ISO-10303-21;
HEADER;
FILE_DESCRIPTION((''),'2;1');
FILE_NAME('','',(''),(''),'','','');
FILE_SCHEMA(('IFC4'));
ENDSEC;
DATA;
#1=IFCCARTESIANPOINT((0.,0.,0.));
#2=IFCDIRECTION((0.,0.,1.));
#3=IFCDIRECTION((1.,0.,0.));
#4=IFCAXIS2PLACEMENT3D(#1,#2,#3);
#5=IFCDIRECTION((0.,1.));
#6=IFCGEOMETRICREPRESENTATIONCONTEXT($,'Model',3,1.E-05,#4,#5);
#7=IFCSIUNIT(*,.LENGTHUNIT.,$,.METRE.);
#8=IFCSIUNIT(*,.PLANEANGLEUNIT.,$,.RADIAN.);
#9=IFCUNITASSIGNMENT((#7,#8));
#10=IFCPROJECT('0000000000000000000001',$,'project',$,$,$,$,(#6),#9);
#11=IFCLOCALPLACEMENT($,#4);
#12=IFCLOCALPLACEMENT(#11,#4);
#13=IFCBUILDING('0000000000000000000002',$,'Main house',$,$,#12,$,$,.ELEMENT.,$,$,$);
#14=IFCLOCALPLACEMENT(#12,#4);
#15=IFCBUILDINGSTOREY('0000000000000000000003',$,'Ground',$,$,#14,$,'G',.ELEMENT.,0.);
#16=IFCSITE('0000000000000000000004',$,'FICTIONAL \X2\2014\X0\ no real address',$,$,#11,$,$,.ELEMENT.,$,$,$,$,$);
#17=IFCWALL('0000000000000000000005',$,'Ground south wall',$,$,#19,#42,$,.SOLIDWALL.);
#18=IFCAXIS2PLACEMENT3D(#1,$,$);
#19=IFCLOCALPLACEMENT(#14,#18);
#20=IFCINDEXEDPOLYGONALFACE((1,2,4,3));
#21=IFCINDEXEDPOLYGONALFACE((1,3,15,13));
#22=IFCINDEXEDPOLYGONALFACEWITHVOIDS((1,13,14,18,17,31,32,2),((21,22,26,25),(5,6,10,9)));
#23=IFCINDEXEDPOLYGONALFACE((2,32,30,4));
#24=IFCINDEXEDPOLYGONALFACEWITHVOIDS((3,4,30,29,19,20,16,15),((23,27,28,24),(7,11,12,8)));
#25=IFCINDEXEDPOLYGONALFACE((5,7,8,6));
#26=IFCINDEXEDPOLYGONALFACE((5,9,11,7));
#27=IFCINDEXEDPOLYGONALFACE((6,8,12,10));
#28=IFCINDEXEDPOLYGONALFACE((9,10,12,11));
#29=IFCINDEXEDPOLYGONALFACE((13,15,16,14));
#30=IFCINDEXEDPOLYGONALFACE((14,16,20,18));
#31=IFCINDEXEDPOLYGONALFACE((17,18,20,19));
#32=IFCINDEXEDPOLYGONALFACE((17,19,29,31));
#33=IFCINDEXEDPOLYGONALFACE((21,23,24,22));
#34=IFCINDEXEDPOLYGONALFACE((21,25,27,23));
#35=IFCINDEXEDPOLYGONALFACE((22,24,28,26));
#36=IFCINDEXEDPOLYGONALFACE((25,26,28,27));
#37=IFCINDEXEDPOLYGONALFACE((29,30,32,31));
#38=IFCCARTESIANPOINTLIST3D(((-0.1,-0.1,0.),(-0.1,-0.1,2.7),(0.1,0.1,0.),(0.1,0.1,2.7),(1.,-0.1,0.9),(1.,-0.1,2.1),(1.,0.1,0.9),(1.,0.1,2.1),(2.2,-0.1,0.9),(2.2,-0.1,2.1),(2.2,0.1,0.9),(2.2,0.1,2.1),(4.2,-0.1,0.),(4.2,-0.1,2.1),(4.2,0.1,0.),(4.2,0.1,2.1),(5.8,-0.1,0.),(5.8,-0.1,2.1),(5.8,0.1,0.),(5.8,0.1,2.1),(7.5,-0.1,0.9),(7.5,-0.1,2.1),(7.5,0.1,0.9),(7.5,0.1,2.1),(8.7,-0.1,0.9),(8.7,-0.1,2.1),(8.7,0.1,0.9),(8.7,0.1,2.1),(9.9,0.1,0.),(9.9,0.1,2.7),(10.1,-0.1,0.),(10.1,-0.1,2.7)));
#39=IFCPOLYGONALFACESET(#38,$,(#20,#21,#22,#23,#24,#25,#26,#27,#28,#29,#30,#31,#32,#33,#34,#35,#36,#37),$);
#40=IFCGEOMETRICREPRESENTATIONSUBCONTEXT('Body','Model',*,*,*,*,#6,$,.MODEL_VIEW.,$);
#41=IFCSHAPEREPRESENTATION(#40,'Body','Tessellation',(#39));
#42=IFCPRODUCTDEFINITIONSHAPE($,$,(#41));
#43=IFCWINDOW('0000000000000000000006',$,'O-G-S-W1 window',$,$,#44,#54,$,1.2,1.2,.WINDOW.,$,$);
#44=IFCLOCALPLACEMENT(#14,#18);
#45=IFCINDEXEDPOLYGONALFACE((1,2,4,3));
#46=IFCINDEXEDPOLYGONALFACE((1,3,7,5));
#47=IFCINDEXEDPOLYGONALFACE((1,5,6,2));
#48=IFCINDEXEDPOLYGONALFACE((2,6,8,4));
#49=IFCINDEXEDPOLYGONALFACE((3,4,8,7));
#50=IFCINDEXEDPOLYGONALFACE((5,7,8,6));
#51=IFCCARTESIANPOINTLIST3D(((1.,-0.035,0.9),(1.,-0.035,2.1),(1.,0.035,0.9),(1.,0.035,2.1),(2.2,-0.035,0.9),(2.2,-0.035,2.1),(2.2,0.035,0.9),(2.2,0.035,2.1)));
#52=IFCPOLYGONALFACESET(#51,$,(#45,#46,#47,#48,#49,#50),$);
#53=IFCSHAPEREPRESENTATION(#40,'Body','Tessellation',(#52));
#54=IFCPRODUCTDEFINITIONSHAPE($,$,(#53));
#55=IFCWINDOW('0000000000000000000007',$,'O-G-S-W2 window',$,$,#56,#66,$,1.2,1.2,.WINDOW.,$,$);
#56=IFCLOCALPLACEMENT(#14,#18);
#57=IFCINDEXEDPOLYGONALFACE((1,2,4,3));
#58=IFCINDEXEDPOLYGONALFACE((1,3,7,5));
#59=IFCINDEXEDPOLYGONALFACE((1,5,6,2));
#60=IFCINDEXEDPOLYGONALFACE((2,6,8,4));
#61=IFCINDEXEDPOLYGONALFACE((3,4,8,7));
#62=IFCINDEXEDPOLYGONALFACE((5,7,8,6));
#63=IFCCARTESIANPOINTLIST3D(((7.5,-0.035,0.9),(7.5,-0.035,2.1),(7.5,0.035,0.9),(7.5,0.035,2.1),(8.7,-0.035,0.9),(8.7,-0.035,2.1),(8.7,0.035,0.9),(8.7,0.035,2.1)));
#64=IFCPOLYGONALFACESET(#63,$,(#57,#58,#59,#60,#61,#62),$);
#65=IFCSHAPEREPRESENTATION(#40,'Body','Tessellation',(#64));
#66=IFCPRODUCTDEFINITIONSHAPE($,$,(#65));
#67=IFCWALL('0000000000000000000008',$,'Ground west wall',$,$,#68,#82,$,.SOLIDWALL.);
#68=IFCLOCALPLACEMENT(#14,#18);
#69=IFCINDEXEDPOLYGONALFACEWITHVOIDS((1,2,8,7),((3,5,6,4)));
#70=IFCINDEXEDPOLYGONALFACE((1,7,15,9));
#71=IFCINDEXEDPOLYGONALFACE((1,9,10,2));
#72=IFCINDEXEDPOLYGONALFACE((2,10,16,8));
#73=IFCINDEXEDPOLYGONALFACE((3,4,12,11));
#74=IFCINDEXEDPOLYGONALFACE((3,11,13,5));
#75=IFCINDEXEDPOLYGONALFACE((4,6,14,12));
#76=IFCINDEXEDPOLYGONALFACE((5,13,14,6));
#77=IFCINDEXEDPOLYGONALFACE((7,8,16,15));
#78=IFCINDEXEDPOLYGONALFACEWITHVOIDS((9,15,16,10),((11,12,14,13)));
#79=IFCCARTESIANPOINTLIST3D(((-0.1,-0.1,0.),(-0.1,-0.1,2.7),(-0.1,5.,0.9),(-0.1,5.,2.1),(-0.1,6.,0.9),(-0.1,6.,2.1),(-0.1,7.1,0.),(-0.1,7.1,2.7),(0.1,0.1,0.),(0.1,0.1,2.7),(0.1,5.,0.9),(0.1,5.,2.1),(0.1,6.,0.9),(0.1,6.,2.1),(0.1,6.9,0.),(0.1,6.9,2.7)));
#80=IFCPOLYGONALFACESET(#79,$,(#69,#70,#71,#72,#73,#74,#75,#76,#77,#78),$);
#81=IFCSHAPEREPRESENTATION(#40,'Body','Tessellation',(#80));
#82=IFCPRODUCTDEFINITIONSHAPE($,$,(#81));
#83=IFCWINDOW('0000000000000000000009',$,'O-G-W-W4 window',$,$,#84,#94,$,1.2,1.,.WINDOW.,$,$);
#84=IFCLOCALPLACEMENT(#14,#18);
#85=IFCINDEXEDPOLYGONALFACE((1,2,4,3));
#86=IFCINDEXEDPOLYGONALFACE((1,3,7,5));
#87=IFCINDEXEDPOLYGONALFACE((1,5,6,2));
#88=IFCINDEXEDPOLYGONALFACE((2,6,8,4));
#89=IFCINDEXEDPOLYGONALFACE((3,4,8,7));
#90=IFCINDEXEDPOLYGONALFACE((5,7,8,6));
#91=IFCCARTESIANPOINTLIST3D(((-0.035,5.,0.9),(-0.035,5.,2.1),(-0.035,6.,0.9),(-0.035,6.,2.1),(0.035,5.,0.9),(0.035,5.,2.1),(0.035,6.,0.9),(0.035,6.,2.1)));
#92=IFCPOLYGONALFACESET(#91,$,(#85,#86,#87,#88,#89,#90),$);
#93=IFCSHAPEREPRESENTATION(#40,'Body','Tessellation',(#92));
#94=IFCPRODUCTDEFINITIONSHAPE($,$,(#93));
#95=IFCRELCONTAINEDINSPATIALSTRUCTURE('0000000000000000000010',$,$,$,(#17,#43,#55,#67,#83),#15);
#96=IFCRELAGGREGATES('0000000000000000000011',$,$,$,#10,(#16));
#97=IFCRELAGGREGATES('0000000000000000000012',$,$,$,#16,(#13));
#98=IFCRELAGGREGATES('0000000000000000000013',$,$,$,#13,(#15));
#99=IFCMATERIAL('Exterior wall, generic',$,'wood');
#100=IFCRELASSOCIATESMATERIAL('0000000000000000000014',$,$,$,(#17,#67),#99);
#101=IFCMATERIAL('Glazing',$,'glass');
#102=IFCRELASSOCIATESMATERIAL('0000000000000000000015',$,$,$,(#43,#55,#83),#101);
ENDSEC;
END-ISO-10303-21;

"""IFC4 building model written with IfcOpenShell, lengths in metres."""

from ifc_helpers import new_model, si_unit, direction, frame, origin_with_axes, place, context, subcontext, project, spatial, polyline, outline, extrude, material, element, fill, save


model = new_model("IFC4")

# Units and contexts
model_context = context("Model", 3, precision=1e-05, world=origin_with_axes(), true_north=direction((0.0, 1.0)))
body_context = subcontext(model_context, "Body", "Model", "MODEL_VIEW")
ifc_project = project(units=[si_unit("LENGTHUNIT", "METRE"), si_unit("PLANEANGLEUNIT", "RADIAN")], contexts=[model_context])

# Site, building, storey
site_placement = place(None, origin_with_axes())
site = spatial("IfcSite", under=ifc_project, at=site_placement, Name="FICTIONAL — no real address", CompositionType="ELEMENT")
building_placement = place(site_placement, origin_with_axes())
building = spatial("IfcBuilding", under=site, at=building_placement, Name="Main house", CompositionType="ELEMENT")
storey_placement = place(building_placement, origin_with_axes())
storey = spatial("IfcBuildingStorey", under=building, at=storey_placement, Name="Ground", LongName="G", CompositionType="ELEMENT", Elevation=0.0)

# Shared definitions
ifc_material_1 = material(Name="Exterior wall, generic", Category="wood")
ifc_material_2 = material(Name="Glazing", Category="glass")

# Wall, openings, windows
wall_1_placement = place(storey_placement, origin_with_axes())
wall_1 = element("IfcWall", 1, at=wall_1_placement, inside=storey, material=ifc_material_1, Name="Ground south wall", PredefinedType="SOLIDWALL", context=body_context, shape_type="SweptSolid", body=[
    extrude(outline(polyline([(-0.1, -0.1), (10.1, -0.1), (9.9, 0.1), (0.1, 0.1), (-0.1, -0.1)])), origin_with_axes(), (0.0, 0.0, 1.0), 2.7),
])
opening_1_placement = place(storey_placement, origin_with_axes())
element("IfcOpeningElement", 2, at=opening_1_placement, cuts=wall_1, PredefinedType="OPENING", context=body_context, shape_type="SweptSolid", body=[
    extrude(outline(polyline([(4.2, -0.105), (5.8, -0.105), (5.8, 0.105), (4.2, 0.105), (4.2, -0.105)])), origin_with_axes(), (0.0, 0.0, 1.0), 2.1),
])
opening_2_placement = place(storey_placement, origin_with_axes())
opening_2 = element("IfcOpeningElement", 3, at=opening_2_placement, cuts=wall_1, PredefinedType="OPENING", context=body_context, shape_type="SweptSolid", body=[
    extrude(outline(polyline([(1.0, -0.105), (2.2, -0.105), (2.2, 0.105), (1.0, 0.105), (1.0, -0.105)])), frame((0.0, 0.0, 0.9), z_axis=(0.0, 0.0, 1.0), x_axis=(1.0, 0.0, 0.0)), (0.0, 0.0, 1.0), 1.2),
])
opening_3_placement = place(storey_placement, origin_with_axes())
opening_3 = element("IfcOpeningElement", 4, at=opening_3_placement, cuts=wall_1, PredefinedType="OPENING", context=body_context, shape_type="SweptSolid", body=[
    extrude(outline(polyline([(7.5, -0.105), (8.7, -0.105), (8.7, 0.105), (7.5, 0.105), (7.5, -0.105)])), frame((0.0, 0.0, 0.9), z_axis=(0.0, 0.0, 1.0), x_axis=(1.0, 0.0, 0.0)), (0.0, 0.0, 1.0), 1.2),
])
window_1_placement = place(storey_placement, origin_with_axes())
window_1 = element("IfcWindow", 5, at=window_1_placement, inside=storey, material=ifc_material_2, Name="O-G-S-W1 window", OverallHeight=1.2, OverallWidth=1.2, PredefinedType="WINDOW", context=body_context, shape_type="SweptSolid", body=[
    extrude(outline(polyline([(1.0, -0.035), (2.2, -0.035), (2.2, 0.035), (1.0, 0.035), (1.0, -0.035)])), frame((0.0, 0.0, 0.9), z_axis=(0.0, 0.0, 1.0), x_axis=(1.0, 0.0, 0.0)), (0.0, 0.0, 1.0), 1.2),
])
fill(opening_2, window_1)
window_2_placement = place(storey_placement, origin_with_axes())
window_2 = element("IfcWindow", 6, at=window_2_placement, inside=storey, material=ifc_material_2, Name="O-G-S-W2 window", OverallHeight=1.2, OverallWidth=1.2, PredefinedType="WINDOW", context=body_context, shape_type="SweptSolid", body=[
    extrude(outline(polyline([(7.5, -0.035), (8.7, -0.035), (8.7, 0.035), (7.5, 0.035), (7.5, -0.035)])), frame((0.0, 0.0, 0.9), z_axis=(0.0, 0.0, 1.0), x_axis=(1.0, 0.0, 0.0)), (0.0, 0.0, 1.0), 1.2),
])
fill(opening_3, window_2)

# Wall, opening, window
wall_2_placement = place(storey_placement, origin_with_axes())
wall_2 = element("IfcWall", 7, at=wall_2_placement, inside=storey, material=ifc_material_1, Name="Ground west wall", PredefinedType="SOLIDWALL", context=body_context, shape_type="SweptSolid", body=[
    extrude(outline(polyline([(-0.1, 7.1), (-0.1, -0.1), (0.1, 0.1), (0.1, 6.9), (-0.1, 7.1)])), origin_with_axes(), (0.0, 0.0, 1.0), 2.7),
])
opening_4_placement = place(storey_placement, origin_with_axes())
opening_4 = element("IfcOpeningElement", 8, at=opening_4_placement, cuts=wall_2, PredefinedType="OPENING", context=body_context, shape_type="SweptSolid", body=[
    extrude(outline(polyline([(-0.105, 6.0), (-0.105, 5.0), (0.105, 5.0), (0.105, 6.0), (-0.105, 6.0)])), frame((0.0, 0.0, 0.9), z_axis=(0.0, 0.0, 1.0), x_axis=(1.0, 0.0, 0.0)), (0.0, 0.0, 1.0), 1.2),
])
window_3_placement = place(storey_placement, origin_with_axes())
window_3 = element("IfcWindow", 9, at=window_3_placement, inside=storey, material=ifc_material_2, Name="O-G-W-W4 window", OverallHeight=1.2, OverallWidth=1.0, PredefinedType="WINDOW", context=body_context, shape_type="SweptSolid", body=[
    extrude(outline(polyline([(-0.035, 6.0), (-0.035, 5.0), (0.035, 5.0), (0.035, 6.0), (-0.035, 6.0)])), frame((0.0, 0.0, 0.9), z_axis=(0.0, 0.0, 1.0), x_axis=(1.0, 0.0, 0.0)), (0.0, 0.0, 1.0), 1.2),
])
fill(opening_4, window_3)

save(model, "model.ifc")
